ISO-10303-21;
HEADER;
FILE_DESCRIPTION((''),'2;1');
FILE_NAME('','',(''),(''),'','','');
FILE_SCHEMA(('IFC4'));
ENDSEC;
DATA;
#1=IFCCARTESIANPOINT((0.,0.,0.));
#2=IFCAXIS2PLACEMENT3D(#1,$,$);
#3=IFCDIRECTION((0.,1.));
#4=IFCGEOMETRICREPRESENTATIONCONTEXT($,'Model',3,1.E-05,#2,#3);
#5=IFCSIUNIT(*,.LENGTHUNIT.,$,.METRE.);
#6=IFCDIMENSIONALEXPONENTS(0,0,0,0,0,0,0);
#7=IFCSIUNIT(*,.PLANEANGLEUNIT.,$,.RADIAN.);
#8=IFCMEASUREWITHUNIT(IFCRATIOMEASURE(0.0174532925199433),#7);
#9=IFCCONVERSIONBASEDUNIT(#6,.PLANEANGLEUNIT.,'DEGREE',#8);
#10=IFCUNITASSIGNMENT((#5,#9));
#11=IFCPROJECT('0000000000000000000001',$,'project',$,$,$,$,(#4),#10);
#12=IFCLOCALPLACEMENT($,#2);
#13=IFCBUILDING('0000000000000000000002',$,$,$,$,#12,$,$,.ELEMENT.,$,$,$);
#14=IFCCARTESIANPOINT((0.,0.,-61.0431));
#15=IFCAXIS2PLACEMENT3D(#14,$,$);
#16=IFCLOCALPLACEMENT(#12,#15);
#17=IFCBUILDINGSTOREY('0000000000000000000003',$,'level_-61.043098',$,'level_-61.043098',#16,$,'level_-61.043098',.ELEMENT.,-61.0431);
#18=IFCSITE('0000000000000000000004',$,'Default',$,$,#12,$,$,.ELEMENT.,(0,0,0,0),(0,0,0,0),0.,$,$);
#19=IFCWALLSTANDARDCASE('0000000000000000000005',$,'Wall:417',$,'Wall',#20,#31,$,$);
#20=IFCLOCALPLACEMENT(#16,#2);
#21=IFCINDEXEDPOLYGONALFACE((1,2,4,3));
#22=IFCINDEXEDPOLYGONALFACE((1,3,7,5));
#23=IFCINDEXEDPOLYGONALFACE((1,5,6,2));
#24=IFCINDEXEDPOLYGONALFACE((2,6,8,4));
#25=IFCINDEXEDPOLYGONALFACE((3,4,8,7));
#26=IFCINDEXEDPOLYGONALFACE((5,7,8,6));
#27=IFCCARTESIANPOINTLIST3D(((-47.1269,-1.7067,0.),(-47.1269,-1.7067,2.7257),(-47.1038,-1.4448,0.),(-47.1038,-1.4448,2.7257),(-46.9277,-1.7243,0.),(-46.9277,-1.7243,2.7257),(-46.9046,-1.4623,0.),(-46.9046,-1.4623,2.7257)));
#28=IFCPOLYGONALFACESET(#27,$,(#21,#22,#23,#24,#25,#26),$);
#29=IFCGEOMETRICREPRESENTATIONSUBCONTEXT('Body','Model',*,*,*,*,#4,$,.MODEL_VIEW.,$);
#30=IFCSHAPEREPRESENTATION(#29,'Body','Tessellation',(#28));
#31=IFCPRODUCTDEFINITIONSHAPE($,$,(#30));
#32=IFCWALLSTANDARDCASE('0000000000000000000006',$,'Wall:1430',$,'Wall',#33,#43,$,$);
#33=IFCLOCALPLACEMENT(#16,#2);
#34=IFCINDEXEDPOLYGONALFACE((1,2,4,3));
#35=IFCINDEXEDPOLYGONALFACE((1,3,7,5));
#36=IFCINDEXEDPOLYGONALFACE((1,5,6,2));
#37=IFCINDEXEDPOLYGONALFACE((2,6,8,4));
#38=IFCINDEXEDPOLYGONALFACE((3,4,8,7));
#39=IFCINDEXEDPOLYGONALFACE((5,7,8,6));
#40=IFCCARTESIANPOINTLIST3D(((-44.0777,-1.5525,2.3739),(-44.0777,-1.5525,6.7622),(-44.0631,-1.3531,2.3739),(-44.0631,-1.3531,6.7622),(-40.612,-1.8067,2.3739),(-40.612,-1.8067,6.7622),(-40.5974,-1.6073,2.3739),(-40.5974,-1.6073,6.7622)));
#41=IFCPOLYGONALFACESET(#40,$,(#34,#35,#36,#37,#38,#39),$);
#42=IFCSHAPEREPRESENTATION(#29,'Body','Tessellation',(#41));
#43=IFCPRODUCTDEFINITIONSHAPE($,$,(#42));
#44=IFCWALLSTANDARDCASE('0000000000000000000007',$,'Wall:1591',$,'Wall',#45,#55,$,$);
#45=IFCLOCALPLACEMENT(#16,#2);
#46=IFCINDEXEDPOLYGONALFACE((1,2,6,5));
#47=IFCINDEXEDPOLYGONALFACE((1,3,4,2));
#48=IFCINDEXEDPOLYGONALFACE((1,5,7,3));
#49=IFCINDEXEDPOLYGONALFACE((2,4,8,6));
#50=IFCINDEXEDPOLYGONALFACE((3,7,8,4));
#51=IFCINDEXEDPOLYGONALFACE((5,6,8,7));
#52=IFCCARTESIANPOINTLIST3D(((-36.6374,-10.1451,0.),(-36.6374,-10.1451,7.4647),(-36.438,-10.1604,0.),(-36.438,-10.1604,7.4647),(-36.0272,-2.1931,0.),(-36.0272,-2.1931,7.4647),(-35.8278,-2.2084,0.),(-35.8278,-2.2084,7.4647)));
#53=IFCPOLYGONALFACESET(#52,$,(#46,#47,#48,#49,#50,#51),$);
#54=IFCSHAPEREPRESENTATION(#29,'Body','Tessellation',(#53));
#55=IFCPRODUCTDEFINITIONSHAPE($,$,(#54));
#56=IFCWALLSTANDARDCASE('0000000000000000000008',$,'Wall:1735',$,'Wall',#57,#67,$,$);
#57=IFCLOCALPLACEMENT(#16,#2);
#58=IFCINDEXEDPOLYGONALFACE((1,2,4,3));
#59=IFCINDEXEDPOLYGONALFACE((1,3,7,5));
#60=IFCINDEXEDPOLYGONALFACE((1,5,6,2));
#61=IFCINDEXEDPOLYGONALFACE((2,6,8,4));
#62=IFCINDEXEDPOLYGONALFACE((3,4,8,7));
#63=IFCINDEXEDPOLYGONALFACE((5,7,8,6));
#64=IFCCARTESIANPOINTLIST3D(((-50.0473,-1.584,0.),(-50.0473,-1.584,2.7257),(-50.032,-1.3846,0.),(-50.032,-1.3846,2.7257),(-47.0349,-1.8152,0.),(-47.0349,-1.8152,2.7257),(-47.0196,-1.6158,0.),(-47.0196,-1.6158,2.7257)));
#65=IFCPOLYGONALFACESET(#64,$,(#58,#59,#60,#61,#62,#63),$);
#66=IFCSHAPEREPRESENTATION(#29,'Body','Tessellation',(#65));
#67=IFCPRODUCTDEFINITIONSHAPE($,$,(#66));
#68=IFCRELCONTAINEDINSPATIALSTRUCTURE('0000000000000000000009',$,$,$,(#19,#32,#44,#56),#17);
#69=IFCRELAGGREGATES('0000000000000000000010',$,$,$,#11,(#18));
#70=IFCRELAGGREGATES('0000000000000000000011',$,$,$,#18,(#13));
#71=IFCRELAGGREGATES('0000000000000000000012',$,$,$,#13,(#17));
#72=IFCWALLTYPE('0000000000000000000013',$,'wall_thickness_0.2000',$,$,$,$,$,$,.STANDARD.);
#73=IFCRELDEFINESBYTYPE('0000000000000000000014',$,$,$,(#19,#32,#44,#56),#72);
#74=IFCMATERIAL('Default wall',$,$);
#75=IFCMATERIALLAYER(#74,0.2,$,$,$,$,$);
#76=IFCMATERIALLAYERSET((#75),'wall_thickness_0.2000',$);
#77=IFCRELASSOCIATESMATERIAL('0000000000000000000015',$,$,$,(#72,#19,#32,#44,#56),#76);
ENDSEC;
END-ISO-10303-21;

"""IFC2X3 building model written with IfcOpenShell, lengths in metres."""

from ifc_helpers import new_model, entity, si_unit, converted_unit, direction, frame, origin, place, context, subcontext, project, spatial, polyline, outline, extrude, material, layer, layer_set, layer_usage, type_object, element, save


model = new_model("IFC2X3")

# Units and contexts
model_context = context("Model", 3, precision=1e-05, world=origin(), true_north=direction((0.0, 1.0)))
body_context = subcontext(model_context, "Body", "Model", "MODEL_VIEW")
ifc_project = project(units=[si_unit("LENGTHUNIT", "METRE"), converted_unit("PLANEANGLEUNIT", "DEGREE", entity("IfcRatioMeasure", 0.0174532925199433), si_unit("PLANEANGLEUNIT", "RADIAN"), dimensions=[0, 0, 0, 0, 0, 0, 0])], contexts=[model_context])

# Site, building, storey
placement_1 = place(None, origin())
site = spatial("IfcSite", under=ifc_project, at=placement_1, Name="Default", CompositionType="ELEMENT", RefLatitude=(0, 0, 0, 0), RefLongitude=(0, 0, 0, 0), RefElevation=0.0)
building = spatial("IfcBuilding", under=site, at=placement_1, CompositionType="ELEMENT")
storey_placement = place(placement_1, frame((0.0, 0.0, -61.0431)))
storey = spatial("IfcBuildingStorey", under=building, at=storey_placement, Name="level_-61.043098", ObjectType="level_-61.043098", LongName="level_-61.043098", CompositionType="ELEMENT", Elevation=-61.0431)

# Walls
ifc_material = material(Name="Default wall")
ifc_layer = layer(ifc_material, 0.2)
ifc_layer_set = layer_set([ifc_layer], Name="wall_thickness_0.2000")
ifc_layer_usage = layer_usage(ifc_layer_set, "AXIS2", "POSITIVE", -0.1)
wall_type = type_object("IfcWallType", Name="wall_thickness_0.2000", PredefinedType="STANDARD", material=ifc_layer_set)
wall_1_placement = place(storey_placement, frame((-47.0273, -1.7155, 0.0), z_axis=(0.0, 0.0, 1.0), x_axis=(0.087626, 0.996153, 0.0)))
element("IfcWallStandardCase", 1, at=wall_1_placement, inside=storey, type_object=wall_type, material=ifc_layer_usage, Name="Wall:417", ObjectType="Wall", context=body_context, shape_type="SweptSolid", body=[
    extrude(outline(polyline([(0.263, -0.1), (0.263, 0.1), (0.0, 0.1), (0.0, -0.1), (0.263, -0.1)])), origin(), (0.0, 0.0, 1.0), 2.7257),
])
placement_2 = place(placement_1, frame((0.0, 0.0, -58.6692)))
wall_2_placement = place(placement_2, frame((-44.0704, -1.4528, 0.0), z_axis=(0.0, 0.0, 1.0), x_axis=(0.997321, -0.073154, 0.0)))
element("IfcWallStandardCase", 2, at=wall_2_placement, inside=storey, type_object=wall_type, material=ifc_layer_usage, Name="Wall:1430", ObjectType="Wall", context=body_context, shape_type="SweptSolid", body=[
    extrude(outline(polyline([(3.475, -0.1), (3.475, 0.1), (0.0, 0.1), (0.0, -0.1), (3.475, -0.1)])), origin(), (0.0, 0.0, 1.0), 4.3883),
])
wall_3_placement = place(storey_placement, frame((-35.9275, -2.2007, 0.0), z_axis=(0.0, 0.0, 1.0), x_axis=(-0.07651, -0.997069, 0.0)))
element("IfcWallStandardCase", 3, at=wall_3_placement, inside=storey, type_object=wall_type, material=ifc_layer_usage, Name="Wall:1591", ObjectType="Wall", context=body_context, shape_type="SweptSolid", body=[
    extrude(outline(polyline([(7.9754, -0.1), (7.9754, 0.1), (0.0, 0.1), (0.0, -0.1), (7.9754, -0.1)])), origin(), (0.0, 0.0, 1.0), 7.4647),
])
wall_4_placement = place(storey_placement, frame((-47.0273, -1.7155, 0.0), z_axis=(0.0, 0.0, 1.0), x_axis=(-0.997067, 0.076531, 0.0)))
element("IfcWallStandardCase", 4, at=wall_4_placement, inside=storey, type_object=wall_type, material=ifc_layer_usage, Name="Wall:1735", ObjectType="Wall", context=body_context, shape_type="SweptSolid", body=[
    extrude(outline(polyline([(3.0212, -0.1), (3.0212, 0.1), (0.0, 0.1), (0.0, -0.1), (3.0212, -0.1)])), origin(), (0.0, 0.0, 1.0), 2.7257),
])

save(model, "model.ifc")
